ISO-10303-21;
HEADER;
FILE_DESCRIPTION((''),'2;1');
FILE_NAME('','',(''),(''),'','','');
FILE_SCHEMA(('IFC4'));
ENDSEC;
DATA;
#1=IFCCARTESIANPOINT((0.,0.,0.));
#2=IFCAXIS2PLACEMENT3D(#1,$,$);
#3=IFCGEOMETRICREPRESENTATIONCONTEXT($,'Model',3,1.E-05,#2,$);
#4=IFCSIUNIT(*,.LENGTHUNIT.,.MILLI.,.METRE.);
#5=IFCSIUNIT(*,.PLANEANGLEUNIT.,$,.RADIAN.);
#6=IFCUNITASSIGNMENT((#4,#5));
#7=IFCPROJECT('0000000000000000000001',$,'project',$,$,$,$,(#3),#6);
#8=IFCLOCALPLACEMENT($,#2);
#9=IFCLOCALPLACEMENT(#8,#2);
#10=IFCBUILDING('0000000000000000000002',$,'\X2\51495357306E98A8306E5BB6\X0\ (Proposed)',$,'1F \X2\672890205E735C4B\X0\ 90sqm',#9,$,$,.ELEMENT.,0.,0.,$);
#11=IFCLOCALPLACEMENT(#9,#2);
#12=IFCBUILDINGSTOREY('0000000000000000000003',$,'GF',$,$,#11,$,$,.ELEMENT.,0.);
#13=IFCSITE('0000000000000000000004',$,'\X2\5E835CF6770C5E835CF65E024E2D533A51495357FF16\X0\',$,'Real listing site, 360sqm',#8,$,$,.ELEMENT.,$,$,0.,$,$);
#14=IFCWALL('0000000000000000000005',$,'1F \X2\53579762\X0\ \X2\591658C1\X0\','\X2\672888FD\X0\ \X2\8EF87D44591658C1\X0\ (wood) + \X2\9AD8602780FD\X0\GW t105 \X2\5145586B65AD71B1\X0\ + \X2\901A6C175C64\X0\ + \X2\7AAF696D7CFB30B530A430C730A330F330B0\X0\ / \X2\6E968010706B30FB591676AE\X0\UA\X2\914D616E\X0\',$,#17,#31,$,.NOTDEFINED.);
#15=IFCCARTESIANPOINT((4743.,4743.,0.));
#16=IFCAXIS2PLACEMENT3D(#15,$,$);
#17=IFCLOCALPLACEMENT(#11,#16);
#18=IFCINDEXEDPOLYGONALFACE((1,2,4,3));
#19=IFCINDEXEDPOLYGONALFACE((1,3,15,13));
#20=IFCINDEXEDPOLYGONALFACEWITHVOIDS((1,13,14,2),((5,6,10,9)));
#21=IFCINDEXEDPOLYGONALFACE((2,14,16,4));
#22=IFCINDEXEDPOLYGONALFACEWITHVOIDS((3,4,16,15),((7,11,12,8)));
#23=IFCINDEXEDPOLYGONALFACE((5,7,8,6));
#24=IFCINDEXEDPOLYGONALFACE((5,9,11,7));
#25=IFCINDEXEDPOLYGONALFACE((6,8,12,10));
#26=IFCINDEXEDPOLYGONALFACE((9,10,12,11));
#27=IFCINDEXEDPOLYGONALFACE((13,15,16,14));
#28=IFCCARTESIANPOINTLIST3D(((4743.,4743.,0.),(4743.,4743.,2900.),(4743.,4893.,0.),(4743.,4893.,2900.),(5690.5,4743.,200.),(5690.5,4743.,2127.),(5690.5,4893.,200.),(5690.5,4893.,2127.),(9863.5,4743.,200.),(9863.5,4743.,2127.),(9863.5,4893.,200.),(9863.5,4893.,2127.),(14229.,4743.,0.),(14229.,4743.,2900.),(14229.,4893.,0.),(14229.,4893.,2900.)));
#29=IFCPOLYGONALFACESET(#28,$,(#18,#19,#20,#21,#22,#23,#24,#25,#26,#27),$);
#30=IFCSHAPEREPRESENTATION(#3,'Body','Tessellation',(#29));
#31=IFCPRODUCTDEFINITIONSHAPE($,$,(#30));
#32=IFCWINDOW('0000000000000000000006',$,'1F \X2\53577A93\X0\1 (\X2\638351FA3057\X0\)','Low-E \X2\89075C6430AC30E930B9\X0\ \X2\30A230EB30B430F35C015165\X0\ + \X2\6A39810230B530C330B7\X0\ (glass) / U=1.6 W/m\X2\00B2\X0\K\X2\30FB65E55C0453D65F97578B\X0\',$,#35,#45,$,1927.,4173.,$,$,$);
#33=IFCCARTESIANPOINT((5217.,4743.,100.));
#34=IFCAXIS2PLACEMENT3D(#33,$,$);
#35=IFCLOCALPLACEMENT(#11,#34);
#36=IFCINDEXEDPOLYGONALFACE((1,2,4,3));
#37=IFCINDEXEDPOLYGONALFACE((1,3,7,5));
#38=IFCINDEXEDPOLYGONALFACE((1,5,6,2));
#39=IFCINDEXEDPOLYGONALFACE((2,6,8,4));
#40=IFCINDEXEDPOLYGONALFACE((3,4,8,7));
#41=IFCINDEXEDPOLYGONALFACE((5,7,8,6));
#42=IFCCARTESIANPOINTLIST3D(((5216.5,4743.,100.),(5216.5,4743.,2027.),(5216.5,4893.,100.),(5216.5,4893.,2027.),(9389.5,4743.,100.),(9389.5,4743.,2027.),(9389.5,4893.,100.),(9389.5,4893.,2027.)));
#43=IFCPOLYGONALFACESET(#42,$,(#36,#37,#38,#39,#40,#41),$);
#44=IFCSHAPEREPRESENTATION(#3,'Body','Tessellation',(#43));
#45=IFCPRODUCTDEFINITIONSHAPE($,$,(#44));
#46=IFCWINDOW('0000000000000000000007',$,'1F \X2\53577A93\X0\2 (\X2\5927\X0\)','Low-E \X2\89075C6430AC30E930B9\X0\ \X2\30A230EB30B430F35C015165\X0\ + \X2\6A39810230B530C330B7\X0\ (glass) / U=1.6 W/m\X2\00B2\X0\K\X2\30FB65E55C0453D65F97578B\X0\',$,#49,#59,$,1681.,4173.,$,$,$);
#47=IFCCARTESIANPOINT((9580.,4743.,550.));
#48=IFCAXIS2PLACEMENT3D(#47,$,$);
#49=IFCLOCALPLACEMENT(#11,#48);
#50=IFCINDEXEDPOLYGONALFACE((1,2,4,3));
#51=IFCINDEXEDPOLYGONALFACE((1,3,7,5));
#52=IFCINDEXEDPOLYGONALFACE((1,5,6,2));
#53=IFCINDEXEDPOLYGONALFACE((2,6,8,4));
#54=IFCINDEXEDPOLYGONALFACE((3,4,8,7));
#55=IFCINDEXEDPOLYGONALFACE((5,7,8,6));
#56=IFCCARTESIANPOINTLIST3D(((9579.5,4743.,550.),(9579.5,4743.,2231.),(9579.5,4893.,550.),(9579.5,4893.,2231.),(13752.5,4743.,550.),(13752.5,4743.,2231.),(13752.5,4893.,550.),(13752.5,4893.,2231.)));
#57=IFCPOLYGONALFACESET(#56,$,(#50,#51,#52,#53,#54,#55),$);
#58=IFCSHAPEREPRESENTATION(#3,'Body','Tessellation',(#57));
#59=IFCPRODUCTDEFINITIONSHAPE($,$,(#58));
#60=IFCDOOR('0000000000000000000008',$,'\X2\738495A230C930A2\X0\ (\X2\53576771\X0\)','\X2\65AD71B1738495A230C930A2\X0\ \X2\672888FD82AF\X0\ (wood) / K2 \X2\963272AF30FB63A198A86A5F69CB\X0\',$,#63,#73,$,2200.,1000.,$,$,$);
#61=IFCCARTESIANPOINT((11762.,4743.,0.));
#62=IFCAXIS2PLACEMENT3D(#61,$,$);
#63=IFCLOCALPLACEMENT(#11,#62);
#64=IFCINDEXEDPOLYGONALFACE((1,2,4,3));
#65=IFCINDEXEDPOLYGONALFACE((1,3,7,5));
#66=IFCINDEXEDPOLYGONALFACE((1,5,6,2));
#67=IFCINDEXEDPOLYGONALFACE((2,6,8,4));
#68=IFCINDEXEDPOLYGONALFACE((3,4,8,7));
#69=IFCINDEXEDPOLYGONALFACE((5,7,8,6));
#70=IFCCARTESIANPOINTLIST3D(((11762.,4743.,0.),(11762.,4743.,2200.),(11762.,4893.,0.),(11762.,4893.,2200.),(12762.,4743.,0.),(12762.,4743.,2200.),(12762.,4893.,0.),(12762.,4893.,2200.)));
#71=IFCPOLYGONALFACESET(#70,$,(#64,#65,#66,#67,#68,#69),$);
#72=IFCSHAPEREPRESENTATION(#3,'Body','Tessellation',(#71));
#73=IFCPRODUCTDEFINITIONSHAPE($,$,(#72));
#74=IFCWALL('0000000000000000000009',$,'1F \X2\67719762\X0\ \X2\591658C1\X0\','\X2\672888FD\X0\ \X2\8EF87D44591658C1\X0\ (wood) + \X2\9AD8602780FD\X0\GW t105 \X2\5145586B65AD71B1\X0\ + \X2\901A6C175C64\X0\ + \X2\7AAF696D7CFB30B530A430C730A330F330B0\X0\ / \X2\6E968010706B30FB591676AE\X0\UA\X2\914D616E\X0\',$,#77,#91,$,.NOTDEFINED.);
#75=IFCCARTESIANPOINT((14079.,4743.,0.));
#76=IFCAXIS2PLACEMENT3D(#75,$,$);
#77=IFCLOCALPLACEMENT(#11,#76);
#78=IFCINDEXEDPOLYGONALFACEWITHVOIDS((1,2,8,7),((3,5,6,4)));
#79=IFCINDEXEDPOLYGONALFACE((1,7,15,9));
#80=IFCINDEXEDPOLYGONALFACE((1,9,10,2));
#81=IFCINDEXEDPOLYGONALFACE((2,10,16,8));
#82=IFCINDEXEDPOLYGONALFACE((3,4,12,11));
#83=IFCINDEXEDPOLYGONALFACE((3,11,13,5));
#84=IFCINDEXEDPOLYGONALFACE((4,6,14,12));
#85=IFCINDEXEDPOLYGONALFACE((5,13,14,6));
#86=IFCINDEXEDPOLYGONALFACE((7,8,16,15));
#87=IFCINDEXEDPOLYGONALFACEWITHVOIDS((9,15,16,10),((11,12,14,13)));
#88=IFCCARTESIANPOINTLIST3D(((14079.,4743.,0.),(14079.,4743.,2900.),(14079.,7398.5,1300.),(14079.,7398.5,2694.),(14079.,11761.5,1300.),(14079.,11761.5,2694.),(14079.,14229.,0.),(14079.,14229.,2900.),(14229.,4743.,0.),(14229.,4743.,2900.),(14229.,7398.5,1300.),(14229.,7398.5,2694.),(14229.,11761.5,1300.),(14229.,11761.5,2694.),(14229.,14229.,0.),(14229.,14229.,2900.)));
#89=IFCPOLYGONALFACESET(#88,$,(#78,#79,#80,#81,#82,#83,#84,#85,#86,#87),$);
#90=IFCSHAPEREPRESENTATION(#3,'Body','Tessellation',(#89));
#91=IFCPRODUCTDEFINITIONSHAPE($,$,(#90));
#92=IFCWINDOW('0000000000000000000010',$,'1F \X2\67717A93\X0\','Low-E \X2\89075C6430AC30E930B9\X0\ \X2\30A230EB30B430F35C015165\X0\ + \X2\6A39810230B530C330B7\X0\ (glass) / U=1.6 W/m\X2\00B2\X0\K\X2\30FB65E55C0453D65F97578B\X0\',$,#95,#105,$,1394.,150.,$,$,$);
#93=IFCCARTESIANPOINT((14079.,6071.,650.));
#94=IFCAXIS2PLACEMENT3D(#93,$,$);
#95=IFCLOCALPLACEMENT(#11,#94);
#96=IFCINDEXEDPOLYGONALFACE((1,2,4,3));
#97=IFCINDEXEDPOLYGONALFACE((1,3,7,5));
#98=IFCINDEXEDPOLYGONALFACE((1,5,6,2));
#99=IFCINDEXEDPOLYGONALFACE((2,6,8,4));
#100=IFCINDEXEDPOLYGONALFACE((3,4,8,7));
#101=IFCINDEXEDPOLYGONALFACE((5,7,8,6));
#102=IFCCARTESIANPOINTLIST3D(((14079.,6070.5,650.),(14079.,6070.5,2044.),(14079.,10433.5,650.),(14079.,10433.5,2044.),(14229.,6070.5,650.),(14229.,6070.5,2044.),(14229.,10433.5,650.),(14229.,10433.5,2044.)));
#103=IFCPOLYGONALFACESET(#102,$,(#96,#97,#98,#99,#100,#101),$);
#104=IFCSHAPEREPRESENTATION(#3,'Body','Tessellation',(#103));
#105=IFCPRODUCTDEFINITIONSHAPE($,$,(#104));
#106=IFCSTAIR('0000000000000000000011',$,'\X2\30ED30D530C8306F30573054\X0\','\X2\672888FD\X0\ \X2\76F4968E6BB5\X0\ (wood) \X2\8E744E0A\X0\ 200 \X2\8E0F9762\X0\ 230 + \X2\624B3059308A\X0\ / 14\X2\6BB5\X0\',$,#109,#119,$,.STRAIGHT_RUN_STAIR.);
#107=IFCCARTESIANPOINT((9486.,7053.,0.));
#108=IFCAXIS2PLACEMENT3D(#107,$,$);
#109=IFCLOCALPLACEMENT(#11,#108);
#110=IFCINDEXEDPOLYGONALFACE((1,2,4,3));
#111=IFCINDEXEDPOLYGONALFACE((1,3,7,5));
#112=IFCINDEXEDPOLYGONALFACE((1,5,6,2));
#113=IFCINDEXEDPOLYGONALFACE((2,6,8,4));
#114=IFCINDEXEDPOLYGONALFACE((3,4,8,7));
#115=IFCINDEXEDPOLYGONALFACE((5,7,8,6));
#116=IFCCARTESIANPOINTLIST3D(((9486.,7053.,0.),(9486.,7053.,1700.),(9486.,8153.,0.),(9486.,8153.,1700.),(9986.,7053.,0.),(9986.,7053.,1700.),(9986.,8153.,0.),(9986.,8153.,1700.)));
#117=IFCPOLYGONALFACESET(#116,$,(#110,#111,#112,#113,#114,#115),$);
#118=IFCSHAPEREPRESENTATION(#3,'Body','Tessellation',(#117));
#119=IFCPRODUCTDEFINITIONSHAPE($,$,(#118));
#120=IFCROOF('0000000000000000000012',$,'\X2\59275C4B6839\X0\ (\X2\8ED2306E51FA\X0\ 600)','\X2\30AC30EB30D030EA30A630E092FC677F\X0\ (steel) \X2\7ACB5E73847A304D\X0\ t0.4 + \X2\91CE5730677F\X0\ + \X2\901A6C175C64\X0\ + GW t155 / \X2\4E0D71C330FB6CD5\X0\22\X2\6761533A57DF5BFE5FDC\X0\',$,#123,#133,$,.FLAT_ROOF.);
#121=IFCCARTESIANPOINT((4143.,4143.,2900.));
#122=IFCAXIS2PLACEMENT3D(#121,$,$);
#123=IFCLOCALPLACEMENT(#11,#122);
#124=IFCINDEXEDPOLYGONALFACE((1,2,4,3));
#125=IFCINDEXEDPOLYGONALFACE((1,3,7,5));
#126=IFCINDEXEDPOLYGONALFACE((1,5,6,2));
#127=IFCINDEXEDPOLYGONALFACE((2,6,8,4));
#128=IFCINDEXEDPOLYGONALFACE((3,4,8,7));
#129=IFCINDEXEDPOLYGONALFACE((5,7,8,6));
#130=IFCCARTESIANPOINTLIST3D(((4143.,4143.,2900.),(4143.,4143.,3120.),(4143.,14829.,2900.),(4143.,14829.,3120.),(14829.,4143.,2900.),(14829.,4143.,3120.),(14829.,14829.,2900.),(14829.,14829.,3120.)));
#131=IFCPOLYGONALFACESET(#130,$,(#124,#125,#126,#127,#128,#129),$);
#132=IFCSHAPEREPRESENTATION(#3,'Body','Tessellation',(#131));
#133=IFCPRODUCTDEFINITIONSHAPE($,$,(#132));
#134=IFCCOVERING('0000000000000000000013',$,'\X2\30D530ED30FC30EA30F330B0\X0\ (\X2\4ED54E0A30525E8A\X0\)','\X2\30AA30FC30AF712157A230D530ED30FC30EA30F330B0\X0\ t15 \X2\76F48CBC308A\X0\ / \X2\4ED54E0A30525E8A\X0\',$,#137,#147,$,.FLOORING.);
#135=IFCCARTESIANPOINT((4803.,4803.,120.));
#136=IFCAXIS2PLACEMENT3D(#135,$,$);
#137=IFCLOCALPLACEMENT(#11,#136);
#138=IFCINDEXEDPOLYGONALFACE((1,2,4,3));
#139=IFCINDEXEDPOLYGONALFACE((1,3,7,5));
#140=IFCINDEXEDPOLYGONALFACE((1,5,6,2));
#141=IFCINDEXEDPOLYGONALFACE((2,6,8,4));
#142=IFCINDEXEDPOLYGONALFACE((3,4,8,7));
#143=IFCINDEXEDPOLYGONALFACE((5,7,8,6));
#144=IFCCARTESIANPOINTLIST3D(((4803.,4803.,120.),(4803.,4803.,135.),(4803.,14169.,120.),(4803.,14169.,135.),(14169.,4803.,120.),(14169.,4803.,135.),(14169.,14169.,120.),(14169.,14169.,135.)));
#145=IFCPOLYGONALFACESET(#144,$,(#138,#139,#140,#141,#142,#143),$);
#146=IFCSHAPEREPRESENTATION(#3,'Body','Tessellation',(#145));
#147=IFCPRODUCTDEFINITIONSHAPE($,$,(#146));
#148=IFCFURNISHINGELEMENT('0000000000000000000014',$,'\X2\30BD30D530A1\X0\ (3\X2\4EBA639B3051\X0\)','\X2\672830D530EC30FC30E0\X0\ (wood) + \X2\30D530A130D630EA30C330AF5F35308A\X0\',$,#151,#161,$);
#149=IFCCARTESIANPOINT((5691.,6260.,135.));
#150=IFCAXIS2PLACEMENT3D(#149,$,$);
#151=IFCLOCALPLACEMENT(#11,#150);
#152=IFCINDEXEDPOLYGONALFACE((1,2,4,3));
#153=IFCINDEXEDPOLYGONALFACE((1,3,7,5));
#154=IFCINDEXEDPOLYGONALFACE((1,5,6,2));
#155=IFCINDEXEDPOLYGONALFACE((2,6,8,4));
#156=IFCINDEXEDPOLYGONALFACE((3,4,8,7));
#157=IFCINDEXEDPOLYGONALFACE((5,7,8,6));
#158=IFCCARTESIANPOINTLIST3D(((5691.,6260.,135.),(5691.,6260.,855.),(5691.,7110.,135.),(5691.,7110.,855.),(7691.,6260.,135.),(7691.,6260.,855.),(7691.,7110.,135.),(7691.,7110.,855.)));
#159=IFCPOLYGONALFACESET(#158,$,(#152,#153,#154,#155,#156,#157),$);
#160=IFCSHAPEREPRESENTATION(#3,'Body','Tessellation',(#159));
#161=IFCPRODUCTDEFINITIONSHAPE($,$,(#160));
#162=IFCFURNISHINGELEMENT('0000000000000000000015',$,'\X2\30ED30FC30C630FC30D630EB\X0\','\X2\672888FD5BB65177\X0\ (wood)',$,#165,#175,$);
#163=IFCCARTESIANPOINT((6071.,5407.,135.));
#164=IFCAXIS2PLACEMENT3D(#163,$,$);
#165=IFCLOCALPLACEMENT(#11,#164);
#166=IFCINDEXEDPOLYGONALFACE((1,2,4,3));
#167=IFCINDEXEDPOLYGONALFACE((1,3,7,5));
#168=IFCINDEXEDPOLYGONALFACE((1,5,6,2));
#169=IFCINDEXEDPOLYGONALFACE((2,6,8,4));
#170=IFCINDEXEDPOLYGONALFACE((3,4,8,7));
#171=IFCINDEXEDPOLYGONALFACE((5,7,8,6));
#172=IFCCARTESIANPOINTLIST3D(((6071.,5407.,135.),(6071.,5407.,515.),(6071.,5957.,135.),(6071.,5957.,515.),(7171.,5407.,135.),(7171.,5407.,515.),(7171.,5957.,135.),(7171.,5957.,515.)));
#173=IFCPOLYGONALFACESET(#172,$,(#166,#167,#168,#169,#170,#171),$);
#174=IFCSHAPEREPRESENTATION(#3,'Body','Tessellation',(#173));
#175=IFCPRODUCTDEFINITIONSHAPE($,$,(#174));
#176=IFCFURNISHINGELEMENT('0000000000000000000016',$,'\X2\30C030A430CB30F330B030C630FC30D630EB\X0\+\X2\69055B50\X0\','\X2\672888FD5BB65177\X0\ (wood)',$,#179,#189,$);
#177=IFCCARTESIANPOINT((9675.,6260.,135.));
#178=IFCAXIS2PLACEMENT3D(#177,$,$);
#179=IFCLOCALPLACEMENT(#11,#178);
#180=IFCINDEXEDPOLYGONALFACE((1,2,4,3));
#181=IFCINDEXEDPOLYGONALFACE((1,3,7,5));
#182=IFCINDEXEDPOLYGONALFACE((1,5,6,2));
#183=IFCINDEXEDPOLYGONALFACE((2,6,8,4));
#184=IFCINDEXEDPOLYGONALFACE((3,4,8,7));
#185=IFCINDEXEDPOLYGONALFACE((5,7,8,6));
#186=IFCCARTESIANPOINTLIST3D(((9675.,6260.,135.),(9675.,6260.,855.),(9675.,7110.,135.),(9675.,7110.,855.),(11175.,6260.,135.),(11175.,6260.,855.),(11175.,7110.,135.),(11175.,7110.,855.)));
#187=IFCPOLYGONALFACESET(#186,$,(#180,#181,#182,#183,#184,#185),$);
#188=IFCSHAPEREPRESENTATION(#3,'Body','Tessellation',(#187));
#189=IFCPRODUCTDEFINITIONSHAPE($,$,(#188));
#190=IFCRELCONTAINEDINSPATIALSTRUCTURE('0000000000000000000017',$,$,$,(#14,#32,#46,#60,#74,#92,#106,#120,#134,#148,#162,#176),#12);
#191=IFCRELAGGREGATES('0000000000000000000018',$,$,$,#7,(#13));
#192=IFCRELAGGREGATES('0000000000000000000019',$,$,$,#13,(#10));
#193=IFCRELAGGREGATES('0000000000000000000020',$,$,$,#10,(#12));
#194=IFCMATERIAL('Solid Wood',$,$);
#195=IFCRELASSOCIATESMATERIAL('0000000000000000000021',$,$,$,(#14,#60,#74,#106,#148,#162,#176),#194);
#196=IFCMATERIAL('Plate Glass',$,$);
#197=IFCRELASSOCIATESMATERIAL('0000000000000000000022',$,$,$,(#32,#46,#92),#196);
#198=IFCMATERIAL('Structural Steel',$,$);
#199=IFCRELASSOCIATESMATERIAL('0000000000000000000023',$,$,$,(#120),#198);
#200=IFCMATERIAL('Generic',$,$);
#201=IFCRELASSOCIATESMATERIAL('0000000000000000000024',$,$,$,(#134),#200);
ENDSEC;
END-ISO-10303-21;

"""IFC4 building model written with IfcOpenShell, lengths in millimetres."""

from ifc_helpers import new_model, si_unit, frame, frame_2d, origin, place, context, project, spatial, rectangle, extrude, material, element, fill, save


model = new_model("IFC4")

# Units and contexts
model_context = context("Model", 3, precision=1e-05, world=origin())
ifc_project = project(units=[si_unit("LENGTHUNIT", "METRE", prefix="MILLI"), si_unit("PLANEANGLEUNIT", "RADIAN")], contexts=[model_context])

# Site, building, storey
site_placement = place(None, origin())
site = spatial("IfcSite", under=ifc_project, at=site_placement, Name="広島県広島市中区光南６", ObjectType="Real listing site, 360sqm", CompositionType="ELEMENT", RefElevation=0.0)
building_placement = place(site_placement, origin())
building = spatial("IfcBuilding", under=site, at=building_placement, Name="光南の風の家 (Proposed)", ObjectType="1F 木造平屋 90sqm", CompositionType="ELEMENT", ElevationOfRefHeight=0.0, ElevationOfTerrain=0.0)
storey_placement = place(building_placement, origin())
storey = spatial("IfcBuildingStorey", under=building, at=storey_placement, Name="GF", CompositionType="ELEMENT", Elevation=0.0)

# Shared definitions
ifc_material_1 = material(Name="Solid Wood")

# Wall, openings, windows, door
wall_1_placement = place(storey_placement, frame((4743.0, 4743.0, 0.0)))
wall_1 = element("IfcWall", 1, at=wall_1_placement, inside=storey, material=ifc_material_1, Name="1F 南面 外壁", Description="木製 軸組外壁 (wood) + 高性能GW t105 充填断熱 + 通気層 + 窯業系サイディング / 準耐火・外皮UA配慮", PredefinedType="NOTDEFINED", context=model_context, shape_type="SweptSolid", body=[
    extrude(rectangle(XDim=9486.0, YDim=150.0, at=frame_2d((4743.0, 75.0))), frame((4743.0, 4743.0, 0.0)), (0.0, 0.0, 1.0), 2900.0),
])
opening_1_placement = place(storey_placement, frame((5217.0, 4743.0, 100.0)))
opening_1 = element("IfcOpeningElement", 2, at=opening_1_placement, cuts=wall_1, PredefinedType="NOTDEFINED", context=model_context, shape_type="SweptSolid", body=[
    extrude(rectangle(XDim=4173.0, YDim=150.0, at=frame_2d((2086.0, 75.0))), frame((5217.0, 4743.0, 100.0)), (0.0, 0.0, 1.0), 1927.0),
])
opening_2_placement = place(storey_placement, frame((9580.0, 4743.0, 550.0)))
opening_2 = element("IfcOpeningElement", 3, at=opening_2_placement, cuts=wall_1, PredefinedType="NOTDEFINED", context=model_context, shape_type="SweptSolid", body=[
    extrude(rectangle(XDim=4173.0, YDim=150.0, at=frame_2d((2086.0, 75.0))), frame((9580.0, 4743.0, 550.0)), (0.0, 0.0, 1.0), 1681.0),
])
opening_3_placement = place(storey_placement, frame((11762.0, 4743.0, 0.0)))
opening_3 = element("IfcOpeningElement", 4, at=opening_3_placement, cuts=wall_1, PredefinedType="NOTDEFINED", context=model_context, shape_type="SweptSolid", body=[
    extrude(rectangle(XDim=1000.0, YDim=150.0, at=frame_2d((500.0, 75.0))), frame((11762.0, 4743.0, 0.0)), (0.0, 0.0, 1.0), 2200.0),
])
ifc_material_2 = material(Name="Plate Glass")
window_1_placement = place(storey_placement, frame((5217.0, 4743.0, 100.0)))
window_1 = element("IfcWindow", 5, at=window_1_placement, inside=storey, material=ifc_material_2, Name="1F 南窓1 (掃出し)", Description="Low-E 複層ガラス アルゴン封入 + 樹脂サッシ (glass) / U=1.6 W/m²K・日射取得型", OverallHeight=1927.0, OverallWidth=4173.0, context=model_context, shape_type="SweptSolid", body=[
    extrude(rectangle(XDim=4173.0, YDim=150.0, at=frame_2d((2086.0, 75.0))), frame((5217.0, 4743.0, 100.0)), (0.0, 0.0, 1.0), 1927.0),
])
fill(opening_1, window_1)
window_2_placement = place(storey_placement, frame((9580.0, 4743.0, 550.0)))
window_2 = element("IfcWindow", 6, at=window_2_placement, inside=storey, material=ifc_material_2, Name="1F 南窓2 (大)", Description="Low-E 複層ガラス アルゴン封入 + 樹脂サッシ (glass) / U=1.6 W/m²K・日射取得型", OverallHeight=1681.0, OverallWidth=4173.0, context=model_context, shape_type="SweptSolid", body=[
    extrude(rectangle(XDim=4173.0, YDim=150.0, at=frame_2d((2086.0, 75.0))), frame((9580.0, 4743.0, 550.0)), (0.0, 0.0, 1.0), 1681.0),
])
fill(opening_2, window_2)
door_placement = place(storey_placement, frame((11762.0, 4743.0, 0.0)))
door = element("IfcDoor", 7, at=door_placement, inside=storey, material=ifc_material_1, Name="玄関ドア (南東)", Description="断熱玄関ドア 木製芯 (wood) / K2 防犯・採風機構", OverallHeight=2200.0, OverallWidth=1000.0, context=model_context, shape_type="SweptSolid", body=[
    extrude(rectangle(XDim=1000.0, YDim=150.0, at=frame_2d((500.0, 75.0))), frame((11762.0, 4743.0, 0.0)), (0.0, 0.0, 1.0), 2200.0),
])
fill(opening_3, door)

# Wall, opening, window
wall_2_placement = place(storey_placement, frame((14079.0, 4743.0, 0.0)))
wall_2 = element("IfcWall", 8, at=wall_2_placement, inside=storey, material=ifc_material_1, Name="1F 東面 外壁", Description="木製 軸組外壁 (wood) + 高性能GW t105 充填断熱 + 通気層 + 窯業系サイディング / 準耐火・外皮UA配慮", PredefinedType="NOTDEFINED", context=model_context, shape_type="SweptSolid", body=[
    extrude(rectangle(XDim=150.0, YDim=9486.0, at=frame_2d((75.0, 4743.0))), frame((14079.0, 4743.0, 0.0)), (0.0, 0.0, 1.0), 2900.0),
])
opening_4_placement = place(storey_placement, frame((14079.0, 6071.0, 650.0)))
opening_4 = element("IfcOpeningElement", 9, at=opening_4_placement, cuts=wall_2, PredefinedType="NOTDEFINED", context=model_context, shape_type="SweptSolid", body=[
    extrude(rectangle(XDim=150.0, YDim=4363.0, at=frame_2d((75.0, 2181.0))), frame((14079.0, 6071.0, 650.0)), (0.0, 0.0, 1.0), 1394.0),
])
window_3_placement = place(storey_placement, frame((14079.0, 6071.0, 650.0)))
window_3 = element("IfcWindow", 10, at=window_3_placement, inside=storey, material=ifc_material_2, Name="1F 東窓", Description="Low-E 複層ガラス アルゴン封入 + 樹脂サッシ (glass) / U=1.6 W/m²K・日射取得型", OverallHeight=1394.0, OverallWidth=150.0, context=model_context, shape_type="SweptSolid", body=[
    extrude(rectangle(XDim=150.0, YDim=4363.0, at=frame_2d((75.0, 2181.0))), frame((14079.0, 6071.0, 650.0)), (0.0, 0.0, 1.0), 1394.0),
])
fill(opening_4, window_3)

# Stair
stair_placement = place(storey_placement, frame((9486.0, 7053.0, 0.0)))
element("IfcStair", 11, at=stair_placement, inside=storey, material=ifc_material_1, Name="ロフトはしご", Description="木製 直階段 (wood) 蹴上 200 踏面 230 + 手すり / 14段", PredefinedType="STRAIGHT_RUN_STAIR", context=model_context, shape_type="SweptSolid", body=[
    extrude(rectangle(XDim=500.0, YDim=1100.0, at=frame_2d((250.0, 550.0))), frame((9486.0, 7053.0, 0.0)), (0.0, 0.0, 1.0), 1700.0),
])

# Roof
ifc_material_3 = material(Name="Structural Steel")
roof_placement = place(storey_placement, frame((4143.0, 4143.0, 2900.0)))
element("IfcRoof", 12, at=roof_placement, inside=storey, material=ifc_material_3, Name="大屋根 (軒の出 600)", Description="ガルバリウム鋼板 (steel) 立平葺き t0.4 + 野地板 + 通気層 + GW t155 / 不燃・法22条区域対応", PredefinedType="FLAT_ROOF", context=model_context, shape_type="SweptSolid", body=[
    extrude(rectangle(XDim=10686.0, YDim=10686.0, at=frame_2d((5343.0, 5343.0))), frame((4143.0, 4143.0, 2900.0)), (0.0, 0.0, 1.0), 220.0),
])

# Covering
ifc_material_4 = material(Name="Generic")
covering_placement = place(storey_placement, frame((4803.0, 4803.0, 120.0)))
element("IfcCovering", 13, at=covering_placement, inside=storey, material=ifc_material_4, Name="フローリング (仕上げ床)", Description="オーク無垢フローリング t15 直貼り / 仕上げ床", PredefinedType="FLOORING", context=model_context, shape_type="SweptSolid", body=[
    extrude(rectangle(XDim=9366.0, YDim=9366.0, at=frame_2d((4683.0, 4683.0))), frame((4803.0, 4803.0, 120.0)), (0.0, 0.0, 1.0), 15.0),
])

# Furnishing elements
furnishing_1_placement = place(storey_placement, frame((5691.0, 6260.0, 135.0)))
element("IfcFurnishingElement", 14, at=furnishing_1_placement, inside=storey, material=ifc_material_1, Name="ソファ (3人掛け)", Description="木フレーム (wood) + ファブリック張り", context=model_context, shape_type="SweptSolid", body=[
    extrude(rectangle(XDim=2000.0, YDim=850.0, at=frame_2d((1000.0, 425.0))), frame((5691.0, 6260.0, 135.0)), (0.0, 0.0, 1.0), 720.0),
])
furnishing_2_placement = place(storey_placement, frame((6071.0, 5407.0, 135.0)))
element("IfcFurnishingElement", 15, at=furnishing_2_placement, inside=storey, material=ifc_material_1, Name="ローテーブル", Description="木製家具 (wood)", context=model_context, shape_type="SweptSolid", body=[
    extrude(rectangle(XDim=1100.0, YDim=550.0, at=frame_2d((550.0, 275.0))), frame((6071.0, 5407.0, 135.0)), (0.0, 0.0, 1.0), 380.0),
])
furnishing_3_placement = place(storey_placement, frame((9675.0, 6260.0, 135.0)))
element("IfcFurnishingElement", 16, at=furnishing_3_placement, inside=storey, material=ifc_material_1, Name="ダイニングテーブル+椅子", Description="木製家具 (wood)", context=model_context, shape_type="SweptSolid", body=[
    extrude(rectangle(XDim=1500.0, YDim=850.0, at=frame_2d((750.0, 425.0))), frame((9675.0, 6260.0, 135.0)), (0.0, 0.0, 1.0), 720.0),
])

save(model, "model.ifc")
